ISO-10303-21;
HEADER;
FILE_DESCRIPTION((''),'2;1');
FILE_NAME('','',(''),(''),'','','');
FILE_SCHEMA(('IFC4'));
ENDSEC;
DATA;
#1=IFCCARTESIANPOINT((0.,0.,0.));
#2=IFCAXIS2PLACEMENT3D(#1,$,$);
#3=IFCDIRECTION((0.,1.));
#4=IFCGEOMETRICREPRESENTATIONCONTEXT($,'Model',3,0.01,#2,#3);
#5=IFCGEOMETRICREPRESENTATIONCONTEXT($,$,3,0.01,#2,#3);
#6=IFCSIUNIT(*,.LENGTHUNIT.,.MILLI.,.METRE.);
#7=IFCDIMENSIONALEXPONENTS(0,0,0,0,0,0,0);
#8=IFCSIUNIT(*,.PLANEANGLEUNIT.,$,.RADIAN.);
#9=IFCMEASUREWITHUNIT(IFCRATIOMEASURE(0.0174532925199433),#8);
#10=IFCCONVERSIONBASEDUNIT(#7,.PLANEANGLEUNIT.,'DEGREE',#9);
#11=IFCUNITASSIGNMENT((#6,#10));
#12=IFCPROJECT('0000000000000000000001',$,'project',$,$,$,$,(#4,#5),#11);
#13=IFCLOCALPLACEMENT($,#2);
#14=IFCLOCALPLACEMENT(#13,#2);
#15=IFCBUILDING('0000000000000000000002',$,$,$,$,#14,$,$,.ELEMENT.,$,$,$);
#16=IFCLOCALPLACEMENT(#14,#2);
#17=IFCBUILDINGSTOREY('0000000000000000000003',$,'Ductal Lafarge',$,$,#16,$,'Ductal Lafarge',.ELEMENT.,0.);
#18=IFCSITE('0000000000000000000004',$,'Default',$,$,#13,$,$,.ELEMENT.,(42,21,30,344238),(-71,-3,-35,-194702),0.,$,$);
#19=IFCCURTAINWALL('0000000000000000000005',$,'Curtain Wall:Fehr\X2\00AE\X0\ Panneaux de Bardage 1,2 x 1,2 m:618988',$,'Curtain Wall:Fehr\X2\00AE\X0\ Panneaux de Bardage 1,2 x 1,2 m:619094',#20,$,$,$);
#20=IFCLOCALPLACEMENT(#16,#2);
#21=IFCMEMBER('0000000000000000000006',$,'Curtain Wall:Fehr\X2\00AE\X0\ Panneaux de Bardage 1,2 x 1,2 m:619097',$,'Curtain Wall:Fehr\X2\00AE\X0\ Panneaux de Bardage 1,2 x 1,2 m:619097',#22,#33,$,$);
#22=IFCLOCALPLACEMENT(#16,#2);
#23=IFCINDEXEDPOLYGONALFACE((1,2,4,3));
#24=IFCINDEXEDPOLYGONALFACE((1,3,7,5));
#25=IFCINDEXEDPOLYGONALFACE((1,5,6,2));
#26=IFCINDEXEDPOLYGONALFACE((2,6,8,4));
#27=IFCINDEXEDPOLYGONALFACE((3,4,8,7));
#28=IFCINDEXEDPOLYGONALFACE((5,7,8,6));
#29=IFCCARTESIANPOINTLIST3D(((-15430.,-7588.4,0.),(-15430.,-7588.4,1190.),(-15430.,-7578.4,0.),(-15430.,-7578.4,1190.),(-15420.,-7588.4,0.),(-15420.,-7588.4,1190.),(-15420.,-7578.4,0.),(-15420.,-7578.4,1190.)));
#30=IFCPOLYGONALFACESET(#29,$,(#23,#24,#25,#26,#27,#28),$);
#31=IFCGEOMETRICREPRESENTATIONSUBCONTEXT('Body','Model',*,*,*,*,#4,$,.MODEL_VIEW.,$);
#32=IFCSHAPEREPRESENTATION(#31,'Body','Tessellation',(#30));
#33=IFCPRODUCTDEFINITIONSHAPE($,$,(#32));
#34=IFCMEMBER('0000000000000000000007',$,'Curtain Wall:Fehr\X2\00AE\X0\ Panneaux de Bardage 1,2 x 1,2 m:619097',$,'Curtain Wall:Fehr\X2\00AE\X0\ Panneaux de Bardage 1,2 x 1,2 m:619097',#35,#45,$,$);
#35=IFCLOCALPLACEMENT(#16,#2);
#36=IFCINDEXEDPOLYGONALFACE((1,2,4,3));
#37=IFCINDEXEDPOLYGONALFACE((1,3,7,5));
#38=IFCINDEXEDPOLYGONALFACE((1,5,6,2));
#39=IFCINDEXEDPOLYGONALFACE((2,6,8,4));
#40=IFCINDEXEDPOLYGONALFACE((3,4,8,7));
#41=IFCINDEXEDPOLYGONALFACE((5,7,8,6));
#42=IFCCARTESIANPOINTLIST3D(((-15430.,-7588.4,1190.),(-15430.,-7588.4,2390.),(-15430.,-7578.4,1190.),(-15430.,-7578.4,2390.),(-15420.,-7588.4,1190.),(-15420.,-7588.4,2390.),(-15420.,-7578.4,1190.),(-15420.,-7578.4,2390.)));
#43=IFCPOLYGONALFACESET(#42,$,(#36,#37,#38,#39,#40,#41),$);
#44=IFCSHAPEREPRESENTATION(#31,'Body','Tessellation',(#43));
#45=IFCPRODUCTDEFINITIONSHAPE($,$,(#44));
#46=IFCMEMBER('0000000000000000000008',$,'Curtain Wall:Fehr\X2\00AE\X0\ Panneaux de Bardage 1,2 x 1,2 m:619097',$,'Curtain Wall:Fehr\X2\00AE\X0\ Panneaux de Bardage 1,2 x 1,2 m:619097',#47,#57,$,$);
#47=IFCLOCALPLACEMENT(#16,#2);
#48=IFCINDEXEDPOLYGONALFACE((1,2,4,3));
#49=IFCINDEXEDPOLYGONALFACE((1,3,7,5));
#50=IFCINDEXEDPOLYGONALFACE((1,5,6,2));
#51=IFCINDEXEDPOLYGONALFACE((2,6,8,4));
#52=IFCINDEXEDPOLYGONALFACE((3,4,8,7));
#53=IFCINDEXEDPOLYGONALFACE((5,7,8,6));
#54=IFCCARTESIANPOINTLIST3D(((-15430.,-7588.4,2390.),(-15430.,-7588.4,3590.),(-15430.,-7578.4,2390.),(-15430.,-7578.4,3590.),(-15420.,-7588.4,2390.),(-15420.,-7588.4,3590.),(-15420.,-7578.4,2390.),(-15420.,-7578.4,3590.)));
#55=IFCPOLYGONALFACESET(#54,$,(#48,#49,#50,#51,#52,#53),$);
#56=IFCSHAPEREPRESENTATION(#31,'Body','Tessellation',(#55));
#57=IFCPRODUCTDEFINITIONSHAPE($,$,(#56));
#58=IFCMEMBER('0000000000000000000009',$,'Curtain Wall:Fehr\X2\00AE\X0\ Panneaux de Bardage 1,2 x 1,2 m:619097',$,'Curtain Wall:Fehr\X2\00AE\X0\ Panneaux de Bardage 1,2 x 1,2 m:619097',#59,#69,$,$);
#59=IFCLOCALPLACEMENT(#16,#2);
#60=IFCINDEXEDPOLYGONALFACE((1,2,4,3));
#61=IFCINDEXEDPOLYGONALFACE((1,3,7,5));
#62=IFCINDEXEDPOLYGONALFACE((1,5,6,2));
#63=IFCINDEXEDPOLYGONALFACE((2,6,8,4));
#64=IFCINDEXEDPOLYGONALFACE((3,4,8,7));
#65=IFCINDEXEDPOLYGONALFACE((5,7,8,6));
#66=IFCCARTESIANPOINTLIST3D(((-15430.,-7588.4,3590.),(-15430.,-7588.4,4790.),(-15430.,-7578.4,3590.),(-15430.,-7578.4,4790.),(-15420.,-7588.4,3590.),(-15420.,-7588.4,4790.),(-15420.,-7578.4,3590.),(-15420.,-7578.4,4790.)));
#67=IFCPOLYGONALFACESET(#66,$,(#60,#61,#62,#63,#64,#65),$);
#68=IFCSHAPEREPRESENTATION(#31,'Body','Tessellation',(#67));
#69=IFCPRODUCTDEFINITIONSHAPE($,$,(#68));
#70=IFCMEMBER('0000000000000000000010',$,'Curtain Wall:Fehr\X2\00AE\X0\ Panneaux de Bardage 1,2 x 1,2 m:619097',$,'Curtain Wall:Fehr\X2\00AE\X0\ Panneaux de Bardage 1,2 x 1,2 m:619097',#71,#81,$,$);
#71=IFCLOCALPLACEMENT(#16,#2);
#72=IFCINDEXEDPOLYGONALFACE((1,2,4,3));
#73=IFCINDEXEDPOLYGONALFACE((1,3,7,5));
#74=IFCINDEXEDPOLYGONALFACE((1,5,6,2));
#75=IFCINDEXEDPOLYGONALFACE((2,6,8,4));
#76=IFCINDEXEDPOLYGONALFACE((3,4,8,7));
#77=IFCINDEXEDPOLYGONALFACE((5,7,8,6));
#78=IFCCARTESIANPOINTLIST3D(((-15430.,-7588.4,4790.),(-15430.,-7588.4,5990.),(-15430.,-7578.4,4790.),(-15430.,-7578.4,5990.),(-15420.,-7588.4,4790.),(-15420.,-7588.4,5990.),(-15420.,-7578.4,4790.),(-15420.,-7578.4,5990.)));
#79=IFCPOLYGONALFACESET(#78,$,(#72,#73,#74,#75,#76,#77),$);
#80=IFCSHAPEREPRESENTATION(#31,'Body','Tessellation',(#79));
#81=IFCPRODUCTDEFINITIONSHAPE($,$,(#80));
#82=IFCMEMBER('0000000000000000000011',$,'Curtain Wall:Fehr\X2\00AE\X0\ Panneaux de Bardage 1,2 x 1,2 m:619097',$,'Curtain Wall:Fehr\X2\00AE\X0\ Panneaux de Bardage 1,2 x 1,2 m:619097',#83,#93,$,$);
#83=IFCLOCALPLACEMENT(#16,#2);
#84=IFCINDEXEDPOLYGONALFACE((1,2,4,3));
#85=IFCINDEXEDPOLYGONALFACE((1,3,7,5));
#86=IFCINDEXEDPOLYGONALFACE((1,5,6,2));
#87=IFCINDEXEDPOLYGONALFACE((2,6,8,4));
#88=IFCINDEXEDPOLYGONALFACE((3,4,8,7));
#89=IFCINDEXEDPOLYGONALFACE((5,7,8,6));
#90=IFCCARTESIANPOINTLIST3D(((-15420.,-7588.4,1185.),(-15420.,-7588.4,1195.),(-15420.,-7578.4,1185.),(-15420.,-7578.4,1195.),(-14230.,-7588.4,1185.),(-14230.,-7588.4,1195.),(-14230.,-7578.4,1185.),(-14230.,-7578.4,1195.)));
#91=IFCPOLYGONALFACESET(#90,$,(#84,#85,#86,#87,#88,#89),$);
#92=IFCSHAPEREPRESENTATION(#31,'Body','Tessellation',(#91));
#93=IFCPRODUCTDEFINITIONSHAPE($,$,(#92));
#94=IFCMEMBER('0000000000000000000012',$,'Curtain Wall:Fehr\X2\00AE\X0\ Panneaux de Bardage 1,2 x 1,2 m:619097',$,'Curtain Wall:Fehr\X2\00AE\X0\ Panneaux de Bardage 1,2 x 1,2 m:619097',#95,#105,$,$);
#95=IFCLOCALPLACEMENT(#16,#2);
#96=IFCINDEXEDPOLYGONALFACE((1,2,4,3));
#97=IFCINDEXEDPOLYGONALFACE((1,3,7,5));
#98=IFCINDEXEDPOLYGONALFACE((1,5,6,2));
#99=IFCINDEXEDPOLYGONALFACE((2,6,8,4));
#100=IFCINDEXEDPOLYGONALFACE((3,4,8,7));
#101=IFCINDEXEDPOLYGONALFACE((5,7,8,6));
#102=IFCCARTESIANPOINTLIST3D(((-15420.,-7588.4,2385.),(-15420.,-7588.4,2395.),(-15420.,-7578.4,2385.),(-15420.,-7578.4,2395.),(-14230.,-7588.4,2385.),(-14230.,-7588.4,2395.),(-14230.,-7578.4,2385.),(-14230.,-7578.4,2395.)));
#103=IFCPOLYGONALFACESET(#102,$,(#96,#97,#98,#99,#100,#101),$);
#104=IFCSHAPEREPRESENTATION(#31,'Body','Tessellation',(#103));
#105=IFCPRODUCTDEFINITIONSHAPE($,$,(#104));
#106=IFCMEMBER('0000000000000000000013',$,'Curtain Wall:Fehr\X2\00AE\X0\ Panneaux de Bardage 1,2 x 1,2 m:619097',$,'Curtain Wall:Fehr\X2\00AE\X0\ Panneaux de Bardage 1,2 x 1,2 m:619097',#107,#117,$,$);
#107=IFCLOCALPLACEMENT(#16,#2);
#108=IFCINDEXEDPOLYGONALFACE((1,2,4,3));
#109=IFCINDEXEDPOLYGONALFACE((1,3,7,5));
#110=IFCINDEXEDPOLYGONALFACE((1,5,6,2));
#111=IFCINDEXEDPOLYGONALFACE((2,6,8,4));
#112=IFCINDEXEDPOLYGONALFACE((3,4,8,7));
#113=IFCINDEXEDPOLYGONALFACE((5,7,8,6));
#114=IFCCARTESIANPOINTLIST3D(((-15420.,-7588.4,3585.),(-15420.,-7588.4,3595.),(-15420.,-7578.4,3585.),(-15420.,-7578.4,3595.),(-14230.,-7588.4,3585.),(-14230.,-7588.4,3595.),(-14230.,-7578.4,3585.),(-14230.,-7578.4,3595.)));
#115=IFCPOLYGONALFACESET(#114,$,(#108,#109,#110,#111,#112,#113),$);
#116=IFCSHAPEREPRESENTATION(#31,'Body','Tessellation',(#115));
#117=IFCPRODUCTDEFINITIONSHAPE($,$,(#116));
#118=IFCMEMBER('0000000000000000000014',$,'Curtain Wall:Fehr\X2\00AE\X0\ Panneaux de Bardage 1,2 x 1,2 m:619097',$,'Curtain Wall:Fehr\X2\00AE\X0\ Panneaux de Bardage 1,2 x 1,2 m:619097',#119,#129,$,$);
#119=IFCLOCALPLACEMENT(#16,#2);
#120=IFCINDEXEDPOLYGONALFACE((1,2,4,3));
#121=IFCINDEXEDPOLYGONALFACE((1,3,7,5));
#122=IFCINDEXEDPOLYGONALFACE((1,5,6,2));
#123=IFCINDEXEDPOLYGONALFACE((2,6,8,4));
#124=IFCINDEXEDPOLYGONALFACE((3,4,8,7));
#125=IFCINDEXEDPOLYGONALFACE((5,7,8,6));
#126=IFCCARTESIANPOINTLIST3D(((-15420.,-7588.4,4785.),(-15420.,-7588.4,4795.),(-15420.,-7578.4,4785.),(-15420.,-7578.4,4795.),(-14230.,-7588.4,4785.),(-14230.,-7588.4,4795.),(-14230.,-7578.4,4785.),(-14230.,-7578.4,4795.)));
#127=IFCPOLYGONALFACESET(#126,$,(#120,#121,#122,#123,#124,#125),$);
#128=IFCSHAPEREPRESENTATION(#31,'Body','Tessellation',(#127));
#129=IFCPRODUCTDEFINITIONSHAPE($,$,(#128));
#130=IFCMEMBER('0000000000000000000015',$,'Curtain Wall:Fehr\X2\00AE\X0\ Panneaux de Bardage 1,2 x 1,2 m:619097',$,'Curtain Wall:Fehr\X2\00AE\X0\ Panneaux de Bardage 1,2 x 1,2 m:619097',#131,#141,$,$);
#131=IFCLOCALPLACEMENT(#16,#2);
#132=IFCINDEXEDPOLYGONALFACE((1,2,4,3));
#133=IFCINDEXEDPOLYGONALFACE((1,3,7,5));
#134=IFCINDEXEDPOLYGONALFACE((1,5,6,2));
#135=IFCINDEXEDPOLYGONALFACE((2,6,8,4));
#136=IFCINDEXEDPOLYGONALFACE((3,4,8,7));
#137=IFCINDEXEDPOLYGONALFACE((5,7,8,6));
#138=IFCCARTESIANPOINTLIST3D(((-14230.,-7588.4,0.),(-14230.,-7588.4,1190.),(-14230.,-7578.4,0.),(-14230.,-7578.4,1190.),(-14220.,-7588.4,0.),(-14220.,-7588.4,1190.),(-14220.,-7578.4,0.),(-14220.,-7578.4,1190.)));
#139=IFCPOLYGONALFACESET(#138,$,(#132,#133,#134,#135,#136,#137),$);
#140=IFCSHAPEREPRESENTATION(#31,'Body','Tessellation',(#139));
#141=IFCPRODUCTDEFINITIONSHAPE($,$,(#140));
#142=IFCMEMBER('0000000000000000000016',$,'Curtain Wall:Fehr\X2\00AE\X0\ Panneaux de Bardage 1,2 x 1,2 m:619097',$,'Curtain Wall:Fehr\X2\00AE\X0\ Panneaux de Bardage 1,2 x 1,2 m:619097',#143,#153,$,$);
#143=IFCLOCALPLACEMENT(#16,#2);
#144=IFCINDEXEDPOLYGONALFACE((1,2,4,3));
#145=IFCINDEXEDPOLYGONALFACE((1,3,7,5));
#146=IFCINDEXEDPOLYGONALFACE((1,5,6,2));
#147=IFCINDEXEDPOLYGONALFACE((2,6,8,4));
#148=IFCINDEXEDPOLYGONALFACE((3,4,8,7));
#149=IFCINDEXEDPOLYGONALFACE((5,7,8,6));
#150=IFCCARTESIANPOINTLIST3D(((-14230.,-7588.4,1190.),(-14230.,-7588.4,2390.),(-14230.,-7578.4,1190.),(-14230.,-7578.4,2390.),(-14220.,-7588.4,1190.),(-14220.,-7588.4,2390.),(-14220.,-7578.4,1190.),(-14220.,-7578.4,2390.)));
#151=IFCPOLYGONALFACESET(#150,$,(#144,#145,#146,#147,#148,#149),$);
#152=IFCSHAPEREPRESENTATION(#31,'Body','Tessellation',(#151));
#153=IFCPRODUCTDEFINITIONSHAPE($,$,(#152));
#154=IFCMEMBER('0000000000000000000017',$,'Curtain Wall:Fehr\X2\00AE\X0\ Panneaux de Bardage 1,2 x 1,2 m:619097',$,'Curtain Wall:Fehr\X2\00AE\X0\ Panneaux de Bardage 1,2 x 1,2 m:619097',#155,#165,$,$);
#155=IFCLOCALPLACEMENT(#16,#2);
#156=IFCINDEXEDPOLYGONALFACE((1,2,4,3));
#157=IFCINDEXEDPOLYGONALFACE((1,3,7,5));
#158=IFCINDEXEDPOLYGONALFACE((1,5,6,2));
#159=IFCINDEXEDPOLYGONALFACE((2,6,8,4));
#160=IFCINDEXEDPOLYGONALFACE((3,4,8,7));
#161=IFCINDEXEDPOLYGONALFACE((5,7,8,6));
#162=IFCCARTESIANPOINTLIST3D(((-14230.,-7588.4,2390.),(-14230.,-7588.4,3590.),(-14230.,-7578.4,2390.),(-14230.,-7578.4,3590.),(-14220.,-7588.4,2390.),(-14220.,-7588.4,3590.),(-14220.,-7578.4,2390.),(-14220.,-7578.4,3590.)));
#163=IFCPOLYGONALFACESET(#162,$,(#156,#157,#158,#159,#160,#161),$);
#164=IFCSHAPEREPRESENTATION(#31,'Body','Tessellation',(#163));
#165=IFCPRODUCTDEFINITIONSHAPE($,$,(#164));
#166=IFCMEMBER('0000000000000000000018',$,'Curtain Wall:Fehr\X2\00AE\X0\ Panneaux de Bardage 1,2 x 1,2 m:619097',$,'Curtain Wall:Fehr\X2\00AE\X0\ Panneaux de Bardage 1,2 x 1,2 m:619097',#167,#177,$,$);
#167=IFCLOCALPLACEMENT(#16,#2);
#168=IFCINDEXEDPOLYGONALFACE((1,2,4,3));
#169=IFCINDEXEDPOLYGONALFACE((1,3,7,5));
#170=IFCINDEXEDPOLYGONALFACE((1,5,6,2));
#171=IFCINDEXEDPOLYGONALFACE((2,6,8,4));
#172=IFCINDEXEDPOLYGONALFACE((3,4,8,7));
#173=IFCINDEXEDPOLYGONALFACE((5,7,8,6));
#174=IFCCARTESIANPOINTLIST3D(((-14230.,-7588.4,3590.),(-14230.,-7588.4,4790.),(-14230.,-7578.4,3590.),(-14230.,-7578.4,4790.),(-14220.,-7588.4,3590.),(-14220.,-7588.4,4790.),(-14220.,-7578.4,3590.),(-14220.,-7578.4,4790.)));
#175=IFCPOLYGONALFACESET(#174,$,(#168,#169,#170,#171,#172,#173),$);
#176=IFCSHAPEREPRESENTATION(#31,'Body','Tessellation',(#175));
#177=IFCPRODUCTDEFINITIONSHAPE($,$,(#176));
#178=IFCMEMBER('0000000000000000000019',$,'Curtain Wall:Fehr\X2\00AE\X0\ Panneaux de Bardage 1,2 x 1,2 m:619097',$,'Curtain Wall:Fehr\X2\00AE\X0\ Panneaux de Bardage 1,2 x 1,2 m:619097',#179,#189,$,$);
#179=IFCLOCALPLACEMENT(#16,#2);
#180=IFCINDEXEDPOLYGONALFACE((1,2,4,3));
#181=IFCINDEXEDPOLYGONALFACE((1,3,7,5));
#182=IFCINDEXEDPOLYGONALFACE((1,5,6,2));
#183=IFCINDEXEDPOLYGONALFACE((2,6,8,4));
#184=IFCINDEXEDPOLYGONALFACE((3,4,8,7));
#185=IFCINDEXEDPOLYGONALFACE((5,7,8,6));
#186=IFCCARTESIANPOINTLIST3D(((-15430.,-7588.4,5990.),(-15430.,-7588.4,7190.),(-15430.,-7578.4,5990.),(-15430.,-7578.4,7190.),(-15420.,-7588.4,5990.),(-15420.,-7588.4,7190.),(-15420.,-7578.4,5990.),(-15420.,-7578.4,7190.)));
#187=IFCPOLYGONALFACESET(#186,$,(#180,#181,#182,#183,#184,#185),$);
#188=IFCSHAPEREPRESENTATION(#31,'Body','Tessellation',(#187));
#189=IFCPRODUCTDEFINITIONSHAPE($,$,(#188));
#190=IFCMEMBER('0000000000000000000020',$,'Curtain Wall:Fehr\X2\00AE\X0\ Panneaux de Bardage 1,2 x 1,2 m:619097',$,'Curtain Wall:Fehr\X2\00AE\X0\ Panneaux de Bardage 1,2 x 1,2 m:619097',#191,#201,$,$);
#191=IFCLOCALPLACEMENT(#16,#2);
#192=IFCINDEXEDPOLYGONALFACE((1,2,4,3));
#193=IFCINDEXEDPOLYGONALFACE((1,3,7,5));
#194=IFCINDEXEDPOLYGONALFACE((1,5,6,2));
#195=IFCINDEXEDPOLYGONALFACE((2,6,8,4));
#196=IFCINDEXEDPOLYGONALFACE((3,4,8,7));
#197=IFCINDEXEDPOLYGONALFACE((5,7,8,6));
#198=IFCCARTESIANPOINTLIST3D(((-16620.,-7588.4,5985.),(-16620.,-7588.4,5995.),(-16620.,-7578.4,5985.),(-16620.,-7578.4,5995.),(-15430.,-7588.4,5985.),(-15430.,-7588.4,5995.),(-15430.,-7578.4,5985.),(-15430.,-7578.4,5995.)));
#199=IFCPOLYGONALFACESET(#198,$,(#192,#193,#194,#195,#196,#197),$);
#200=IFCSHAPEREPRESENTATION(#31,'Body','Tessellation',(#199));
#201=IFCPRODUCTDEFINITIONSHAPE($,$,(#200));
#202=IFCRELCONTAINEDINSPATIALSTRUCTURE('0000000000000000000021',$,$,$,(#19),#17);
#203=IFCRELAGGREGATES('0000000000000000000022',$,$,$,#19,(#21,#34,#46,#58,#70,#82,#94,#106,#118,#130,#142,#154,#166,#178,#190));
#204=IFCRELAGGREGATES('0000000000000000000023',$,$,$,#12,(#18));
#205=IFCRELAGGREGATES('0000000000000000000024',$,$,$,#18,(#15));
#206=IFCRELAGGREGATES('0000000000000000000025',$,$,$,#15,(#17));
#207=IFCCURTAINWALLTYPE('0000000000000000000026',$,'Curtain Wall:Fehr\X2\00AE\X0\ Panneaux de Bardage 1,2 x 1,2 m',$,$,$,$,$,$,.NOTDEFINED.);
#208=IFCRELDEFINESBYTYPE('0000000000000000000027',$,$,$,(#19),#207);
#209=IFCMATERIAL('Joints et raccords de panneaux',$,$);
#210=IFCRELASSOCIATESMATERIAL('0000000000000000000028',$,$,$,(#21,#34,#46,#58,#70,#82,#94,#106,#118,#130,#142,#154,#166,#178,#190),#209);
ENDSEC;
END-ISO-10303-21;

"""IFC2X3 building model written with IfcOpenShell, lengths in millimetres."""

from ifc_helpers import new_model, entity, si_unit, converted_unit, direction, frame, frame_2d, origin, origin_2d_with_axis, place, context, subcontext, project, spatial, rectangle, extrude, material, type_object, element, aggregate, save


model = new_model("IFC2X3")

# Units and contexts
model_context = context("Model", 3, precision=0.01, world=origin(), true_north=direction((0.0, 1.0)))
context_of_model = context(None, 3, precision=0.01, world=origin(), true_north=direction((0.0, 1.0)))
body_context = subcontext(model_context, "Body", "Model", "MODEL_VIEW")
ifc_project = project(units=[si_unit("LENGTHUNIT", "METRE", prefix="MILLI"), converted_unit("PLANEANGLEUNIT", "DEGREE", entity("IfcRatioMeasure", 0.0174532925199433), si_unit("PLANEANGLEUNIT", "RADIAN"), dimensions=[0, 0, 0, 0, 0, 0, 0])], contexts=[model_context, context_of_model])

# Site, building, storey
site_placement = place(None, origin())
site = spatial("IfcSite", under=ifc_project, at=site_placement, Name="Default", CompositionType="ELEMENT", RefLatitude=(42, 21, 30, 344238), RefLongitude=(-71, -3, -35, -194702), RefElevation=0.0)
building_placement = place(site_placement, origin())
building = spatial("IfcBuilding", under=site, at=building_placement, CompositionType="ELEMENT")
storey_placement = place(building_placement, origin())
storey = spatial("IfcBuildingStorey", under=building, at=storey_placement, Name="Ductal Lafarge", LongName="Ductal Lafarge", CompositionType="ELEMENT", Elevation=0.0)

# Curtain wall, members
curtain_wall_type = type_object("IfcCurtainWallType", Name="Curtain Wall:Fehr® Panneaux de Bardage 1,2 x 1,2 m", PredefinedType="NOTDEFINED")
curtain_wall_placement = place(storey_placement, origin())
curtain_wall = element("IfcCurtainWall", 1, at=curtain_wall_placement, inside=storey, type_object=curtain_wall_type, Name="Curtain Wall:Fehr® Panneaux de Bardage 1,2 x 1,2 m:618988", ObjectType="Curtain Wall:Fehr® Panneaux de Bardage 1,2 x 1,2 m:619094")
ifc_material_1 = material(Name="Joints et raccords de panneaux")
member_1_placement = place(curtain_wall_placement, frame((-15430.0, -7588.4, 0.0)))
member_1 = element("IfcMember", 2, at=member_1_placement, material=ifc_material_1, Name="Curtain Wall:Fehr® Panneaux de Bardage 1,2 x 1,2 m:619097", ObjectType="Curtain Wall:Fehr® Panneaux de Bardage 1,2 x 1,2 m:619097", context=body_context, shape_type="SweptSolid", body=[
    extrude(rectangle(XDim=10.0, YDim=10.0, at=origin_2d_with_axis()), frame((5.0, 5.0, 0.0), z_axis=(0.0, 0.0, 1.0), x_axis=(0.0, 1.0, 0.0)), (0.0, 0.0, 1.0), 1190.0),
])
member_2_placement = place(curtain_wall_placement, frame((-15430.0, -7588.4, 1190.0)))
member_2 = element("IfcMember", 3, at=member_2_placement, material=ifc_material_1, Name="Curtain Wall:Fehr® Panneaux de Bardage 1,2 x 1,2 m:619097", ObjectType="Curtain Wall:Fehr® Panneaux de Bardage 1,2 x 1,2 m:619097", context=body_context, shape_type="SweptSolid", body=[
    extrude(rectangle(XDim=10.0, YDim=10.0, at=origin_2d_with_axis()), frame((5.0, 5.0, 0.0), z_axis=(0.0, 0.0, 1.0), x_axis=(0.0, 1.0, 0.0)), (0.0, 0.0, 1.0), 1200.0),
])
member_3_placement = place(curtain_wall_placement, frame((-15430.0, -7588.4, 2390.0)))
member_3 = element("IfcMember", 4, at=member_3_placement, material=ifc_material_1, Name="Curtain Wall:Fehr® Panneaux de Bardage 1,2 x 1,2 m:619097", ObjectType="Curtain Wall:Fehr® Panneaux de Bardage 1,2 x 1,2 m:619097", context=body_context, shape_type="SweptSolid", body=[
    extrude(rectangle(XDim=10.0, YDim=10.0, at=origin_2d_with_axis()), frame((5.0, 5.0, 0.0), z_axis=(0.0, 0.0, 1.0), x_axis=(0.0, 1.0, 0.0)), (0.0, 0.0, 1.0), 1200.0),
])
member_4_placement = place(curtain_wall_placement, frame((-15430.0, -7588.4, 3590.0)))
member_4 = element("IfcMember", 5, at=member_4_placement, material=ifc_material_1, Name="Curtain Wall:Fehr® Panneaux de Bardage 1,2 x 1,2 m:619097", ObjectType="Curtain Wall:Fehr® Panneaux de Bardage 1,2 x 1,2 m:619097", context=body_context, shape_type="SweptSolid", body=[
    extrude(rectangle(XDim=10.0, YDim=10.0, at=origin_2d_with_axis()), frame((5.0, 5.0, 0.0), z_axis=(0.0, 0.0, 1.0), x_axis=(0.0, 1.0, 0.0)), (0.0, 0.0, 1.0), 1200.0),
])
member_5_placement = place(curtain_wall_placement, frame((-15430.0, -7588.4, 4790.0)))
member_5 = element("IfcMember", 6, at=member_5_placement, material=ifc_material_1, Name="Curtain Wall:Fehr® Panneaux de Bardage 1,2 x 1,2 m:619097", ObjectType="Curtain Wall:Fehr® Panneaux de Bardage 1,2 x 1,2 m:619097", context=body_context, shape_type="SweptSolid", body=[
    extrude(rectangle(XDim=10.0, YDim=10.0, at=origin_2d_with_axis()), frame((5.0, 5.0, 0.0), z_axis=(0.0, 0.0, 1.0), x_axis=(0.0, 1.0, 0.0)), (0.0, 0.0, 1.0), 1200.0),
])
member_6_placement = place(curtain_wall_placement, frame((-15420.0, -7588.4, 1185.0)))
member_6 = element("IfcMember", 7, at=member_6_placement, material=ifc_material_1, Name="Curtain Wall:Fehr® Panneaux de Bardage 1,2 x 1,2 m:619097", ObjectType="Curtain Wall:Fehr® Panneaux de Bardage 1,2 x 1,2 m:619097", context=body_context, shape_type="SweptSolid", body=[
    extrude(rectangle(XDim=1190.0, YDim=10.0, at=frame_2d((0.0, 0.0), x_axis=(1.0, 0.0))), frame((595.0, 5.0, 0.0), z_axis=(0.0, 0.0, 1.0), x_axis=(-1.0, 0.0, 0.0)), (0.0, 0.0, 1.0), 10.0),
])
member_7_placement = place(curtain_wall_placement, frame((-15420.0, -7588.4, 2385.0)))
member_7 = element("IfcMember", 8, at=member_7_placement, material=ifc_material_1, Name="Curtain Wall:Fehr® Panneaux de Bardage 1,2 x 1,2 m:619097", ObjectType="Curtain Wall:Fehr® Panneaux de Bardage 1,2 x 1,2 m:619097", context=body_context, shape_type="SweptSolid", body=[
    extrude(rectangle(XDim=1190.0, YDim=10.0, at=frame_2d((0.0, 0.0), x_axis=(1.0, 0.0))), frame((595.0, 5.0, 0.0), z_axis=(0.0, 0.0, 1.0), x_axis=(-1.0, 0.0, 0.0)), (0.0, 0.0, 1.0), 10.0),
])
member_8_placement = place(curtain_wall_placement, frame((-15420.0, -7588.4, 3585.0)))
member_8 = element("IfcMember", 9, at=member_8_placement, material=ifc_material_1, Name="Curtain Wall:Fehr® Panneaux de Bardage 1,2 x 1,2 m:619097", ObjectType="Curtain Wall:Fehr® Panneaux de Bardage 1,2 x 1,2 m:619097", context=body_context, shape_type="SweptSolid", body=[
    extrude(rectangle(XDim=1190.0, YDim=10.0, at=frame_2d((0.0, 0.0), x_axis=(1.0, 0.0))), frame((595.0, 5.0, 0.0), z_axis=(0.0, 0.0, 1.0), x_axis=(-1.0, 0.0, 0.0)), (0.0, 0.0, 1.0), 10.0),
])
member_9_placement = place(curtain_wall_placement, frame((-15420.0, -7588.4, 4785.0)))
member_9 = element("IfcMember", 10, at=member_9_placement, material=ifc_material_1, Name="Curtain Wall:Fehr® Panneaux de Bardage 1,2 x 1,2 m:619097", ObjectType="Curtain Wall:Fehr® Panneaux de Bardage 1,2 x 1,2 m:619097", context=body_context, shape_type="SweptSolid", body=[
    extrude(rectangle(XDim=1190.0, YDim=10.0, at=frame_2d((0.0, 0.0), x_axis=(1.0, 0.0))), frame((595.0, 5.0, 0.0), z_axis=(0.0, 0.0, 1.0), x_axis=(-1.0, 0.0, 0.0)), (0.0, 0.0, 1.0), 10.0),
])
member_10_placement = place(curtain_wall_placement, frame((-14230.0, -7588.4, 0.0)))
member_10 = element("IfcMember", 11, at=member_10_placement, material=ifc_material_1, Name="Curtain Wall:Fehr® Panneaux de Bardage 1,2 x 1,2 m:619097", ObjectType="Curtain Wall:Fehr® Panneaux de Bardage 1,2 x 1,2 m:619097", context=body_context, shape_type="SweptSolid", body=[
    extrude(rectangle(XDim=10.0, YDim=10.0, at=origin_2d_with_axis()), frame((5.0, 5.0, 0.0), z_axis=(0.0, 0.0, 1.0), x_axis=(0.0, 1.0, 0.0)), (0.0, 0.0, 1.0), 1190.0),
])
member_11_placement = place(curtain_wall_placement, frame((-14230.0, -7588.4, 1190.0)))
member_11 = element("IfcMember", 12, at=member_11_placement, material=ifc_material_1, Name="Curtain Wall:Fehr® Panneaux de Bardage 1,2 x 1,2 m:619097", ObjectType="Curtain Wall:Fehr® Panneaux de Bardage 1,2 x 1,2 m:619097", context=body_context, shape_type="SweptSolid", body=[
    extrude(rectangle(XDim=10.0, YDim=10.0, at=origin_2d_with_axis()), frame((5.0, 5.0, 0.0), z_axis=(0.0, 0.0, 1.0), x_axis=(0.0, 1.0, 0.0)), (0.0, 0.0, 1.0), 1200.0),
])
member_12_placement = place(curtain_wall_placement, frame((-14230.0, -7588.4, 2390.0)))
member_12 = element("IfcMember", 13, at=member_12_placement, material=ifc_material_1, Name="Curtain Wall:Fehr® Panneaux de Bardage 1,2 x 1,2 m:619097", ObjectType="Curtain Wall:Fehr® Panneaux de Bardage 1,2 x 1,2 m:619097", context=body_context, shape_type="SweptSolid", body=[
    extrude(rectangle(XDim=10.0, YDim=10.0, at=origin_2d_with_axis()), frame((5.0, 5.0, 0.0), z_axis=(0.0, 0.0, 1.0), x_axis=(0.0, 1.0, 0.0)), (0.0, 0.0, 1.0), 1200.0),
])
member_13_placement = place(curtain_wall_placement, frame((-14230.0, -7588.4, 3590.0)))
member_13 = element("IfcMember", 14, at=member_13_placement, material=ifc_material_1, Name="Curtain Wall:Fehr® Panneaux de Bardage 1,2 x 1,2 m:619097", ObjectType="Curtain Wall:Fehr® Panneaux de Bardage 1,2 x 1,2 m:619097", context=body_context, shape_type="SweptSolid", body=[
    extrude(rectangle(XDim=10.0, YDim=10.0, at=origin_2d_with_axis()), frame((5.0, 5.0, 0.0), z_axis=(0.0, 0.0, 1.0), x_axis=(0.0, 1.0, 0.0)), (0.0, 0.0, 1.0), 1200.0),
])
member_14_placement = place(curtain_wall_placement, frame((-15430.0, -7588.4, 5990.0)))
member_14 = element("IfcMember", 15, at=member_14_placement, material=ifc_material_1, Name="Curtain Wall:Fehr® Panneaux de Bardage 1,2 x 1,2 m:619097", ObjectType="Curtain Wall:Fehr® Panneaux de Bardage 1,2 x 1,2 m:619097", context=body_context, shape_type="SweptSolid", body=[
    extrude(rectangle(XDim=10.0, YDim=10.0, at=origin_2d_with_axis()), frame((5.0, 5.0, 0.0), z_axis=(0.0, 0.0, 1.0), x_axis=(0.0, 1.0, 0.0)), (0.0, 0.0, 1.0), 1200.0),
])
member_15_placement = place(curtain_wall_placement, frame((-16620.0, -7588.4, 5985.0)))
member_15 = element("IfcMember", 16, at=member_15_placement, material=ifc_material_1, Name="Curtain Wall:Fehr® Panneaux de Bardage 1,2 x 1,2 m:619097", ObjectType="Curtain Wall:Fehr® Panneaux de Bardage 1,2 x 1,2 m:619097", context=body_context, shape_type="SweptSolid", body=[
    extrude(rectangle(XDim=1190.0, YDim=10.0, at=frame_2d((0.0, 0.0), x_axis=(1.0, 0.0))), frame((595.0, 5.0, 0.0), z_axis=(0.0, 0.0, 1.0), x_axis=(-1.0, 0.0, 0.0)), (0.0, 0.0, 1.0), 10.0),
])
aggregate(curtain_wall, [member_1, member_2, member_3, member_4, member_5, member_6, member_7, member_8, member_9, member_10, member_11, member_12, member_13, member_14, member_15])

save(model, "model.ifc")
